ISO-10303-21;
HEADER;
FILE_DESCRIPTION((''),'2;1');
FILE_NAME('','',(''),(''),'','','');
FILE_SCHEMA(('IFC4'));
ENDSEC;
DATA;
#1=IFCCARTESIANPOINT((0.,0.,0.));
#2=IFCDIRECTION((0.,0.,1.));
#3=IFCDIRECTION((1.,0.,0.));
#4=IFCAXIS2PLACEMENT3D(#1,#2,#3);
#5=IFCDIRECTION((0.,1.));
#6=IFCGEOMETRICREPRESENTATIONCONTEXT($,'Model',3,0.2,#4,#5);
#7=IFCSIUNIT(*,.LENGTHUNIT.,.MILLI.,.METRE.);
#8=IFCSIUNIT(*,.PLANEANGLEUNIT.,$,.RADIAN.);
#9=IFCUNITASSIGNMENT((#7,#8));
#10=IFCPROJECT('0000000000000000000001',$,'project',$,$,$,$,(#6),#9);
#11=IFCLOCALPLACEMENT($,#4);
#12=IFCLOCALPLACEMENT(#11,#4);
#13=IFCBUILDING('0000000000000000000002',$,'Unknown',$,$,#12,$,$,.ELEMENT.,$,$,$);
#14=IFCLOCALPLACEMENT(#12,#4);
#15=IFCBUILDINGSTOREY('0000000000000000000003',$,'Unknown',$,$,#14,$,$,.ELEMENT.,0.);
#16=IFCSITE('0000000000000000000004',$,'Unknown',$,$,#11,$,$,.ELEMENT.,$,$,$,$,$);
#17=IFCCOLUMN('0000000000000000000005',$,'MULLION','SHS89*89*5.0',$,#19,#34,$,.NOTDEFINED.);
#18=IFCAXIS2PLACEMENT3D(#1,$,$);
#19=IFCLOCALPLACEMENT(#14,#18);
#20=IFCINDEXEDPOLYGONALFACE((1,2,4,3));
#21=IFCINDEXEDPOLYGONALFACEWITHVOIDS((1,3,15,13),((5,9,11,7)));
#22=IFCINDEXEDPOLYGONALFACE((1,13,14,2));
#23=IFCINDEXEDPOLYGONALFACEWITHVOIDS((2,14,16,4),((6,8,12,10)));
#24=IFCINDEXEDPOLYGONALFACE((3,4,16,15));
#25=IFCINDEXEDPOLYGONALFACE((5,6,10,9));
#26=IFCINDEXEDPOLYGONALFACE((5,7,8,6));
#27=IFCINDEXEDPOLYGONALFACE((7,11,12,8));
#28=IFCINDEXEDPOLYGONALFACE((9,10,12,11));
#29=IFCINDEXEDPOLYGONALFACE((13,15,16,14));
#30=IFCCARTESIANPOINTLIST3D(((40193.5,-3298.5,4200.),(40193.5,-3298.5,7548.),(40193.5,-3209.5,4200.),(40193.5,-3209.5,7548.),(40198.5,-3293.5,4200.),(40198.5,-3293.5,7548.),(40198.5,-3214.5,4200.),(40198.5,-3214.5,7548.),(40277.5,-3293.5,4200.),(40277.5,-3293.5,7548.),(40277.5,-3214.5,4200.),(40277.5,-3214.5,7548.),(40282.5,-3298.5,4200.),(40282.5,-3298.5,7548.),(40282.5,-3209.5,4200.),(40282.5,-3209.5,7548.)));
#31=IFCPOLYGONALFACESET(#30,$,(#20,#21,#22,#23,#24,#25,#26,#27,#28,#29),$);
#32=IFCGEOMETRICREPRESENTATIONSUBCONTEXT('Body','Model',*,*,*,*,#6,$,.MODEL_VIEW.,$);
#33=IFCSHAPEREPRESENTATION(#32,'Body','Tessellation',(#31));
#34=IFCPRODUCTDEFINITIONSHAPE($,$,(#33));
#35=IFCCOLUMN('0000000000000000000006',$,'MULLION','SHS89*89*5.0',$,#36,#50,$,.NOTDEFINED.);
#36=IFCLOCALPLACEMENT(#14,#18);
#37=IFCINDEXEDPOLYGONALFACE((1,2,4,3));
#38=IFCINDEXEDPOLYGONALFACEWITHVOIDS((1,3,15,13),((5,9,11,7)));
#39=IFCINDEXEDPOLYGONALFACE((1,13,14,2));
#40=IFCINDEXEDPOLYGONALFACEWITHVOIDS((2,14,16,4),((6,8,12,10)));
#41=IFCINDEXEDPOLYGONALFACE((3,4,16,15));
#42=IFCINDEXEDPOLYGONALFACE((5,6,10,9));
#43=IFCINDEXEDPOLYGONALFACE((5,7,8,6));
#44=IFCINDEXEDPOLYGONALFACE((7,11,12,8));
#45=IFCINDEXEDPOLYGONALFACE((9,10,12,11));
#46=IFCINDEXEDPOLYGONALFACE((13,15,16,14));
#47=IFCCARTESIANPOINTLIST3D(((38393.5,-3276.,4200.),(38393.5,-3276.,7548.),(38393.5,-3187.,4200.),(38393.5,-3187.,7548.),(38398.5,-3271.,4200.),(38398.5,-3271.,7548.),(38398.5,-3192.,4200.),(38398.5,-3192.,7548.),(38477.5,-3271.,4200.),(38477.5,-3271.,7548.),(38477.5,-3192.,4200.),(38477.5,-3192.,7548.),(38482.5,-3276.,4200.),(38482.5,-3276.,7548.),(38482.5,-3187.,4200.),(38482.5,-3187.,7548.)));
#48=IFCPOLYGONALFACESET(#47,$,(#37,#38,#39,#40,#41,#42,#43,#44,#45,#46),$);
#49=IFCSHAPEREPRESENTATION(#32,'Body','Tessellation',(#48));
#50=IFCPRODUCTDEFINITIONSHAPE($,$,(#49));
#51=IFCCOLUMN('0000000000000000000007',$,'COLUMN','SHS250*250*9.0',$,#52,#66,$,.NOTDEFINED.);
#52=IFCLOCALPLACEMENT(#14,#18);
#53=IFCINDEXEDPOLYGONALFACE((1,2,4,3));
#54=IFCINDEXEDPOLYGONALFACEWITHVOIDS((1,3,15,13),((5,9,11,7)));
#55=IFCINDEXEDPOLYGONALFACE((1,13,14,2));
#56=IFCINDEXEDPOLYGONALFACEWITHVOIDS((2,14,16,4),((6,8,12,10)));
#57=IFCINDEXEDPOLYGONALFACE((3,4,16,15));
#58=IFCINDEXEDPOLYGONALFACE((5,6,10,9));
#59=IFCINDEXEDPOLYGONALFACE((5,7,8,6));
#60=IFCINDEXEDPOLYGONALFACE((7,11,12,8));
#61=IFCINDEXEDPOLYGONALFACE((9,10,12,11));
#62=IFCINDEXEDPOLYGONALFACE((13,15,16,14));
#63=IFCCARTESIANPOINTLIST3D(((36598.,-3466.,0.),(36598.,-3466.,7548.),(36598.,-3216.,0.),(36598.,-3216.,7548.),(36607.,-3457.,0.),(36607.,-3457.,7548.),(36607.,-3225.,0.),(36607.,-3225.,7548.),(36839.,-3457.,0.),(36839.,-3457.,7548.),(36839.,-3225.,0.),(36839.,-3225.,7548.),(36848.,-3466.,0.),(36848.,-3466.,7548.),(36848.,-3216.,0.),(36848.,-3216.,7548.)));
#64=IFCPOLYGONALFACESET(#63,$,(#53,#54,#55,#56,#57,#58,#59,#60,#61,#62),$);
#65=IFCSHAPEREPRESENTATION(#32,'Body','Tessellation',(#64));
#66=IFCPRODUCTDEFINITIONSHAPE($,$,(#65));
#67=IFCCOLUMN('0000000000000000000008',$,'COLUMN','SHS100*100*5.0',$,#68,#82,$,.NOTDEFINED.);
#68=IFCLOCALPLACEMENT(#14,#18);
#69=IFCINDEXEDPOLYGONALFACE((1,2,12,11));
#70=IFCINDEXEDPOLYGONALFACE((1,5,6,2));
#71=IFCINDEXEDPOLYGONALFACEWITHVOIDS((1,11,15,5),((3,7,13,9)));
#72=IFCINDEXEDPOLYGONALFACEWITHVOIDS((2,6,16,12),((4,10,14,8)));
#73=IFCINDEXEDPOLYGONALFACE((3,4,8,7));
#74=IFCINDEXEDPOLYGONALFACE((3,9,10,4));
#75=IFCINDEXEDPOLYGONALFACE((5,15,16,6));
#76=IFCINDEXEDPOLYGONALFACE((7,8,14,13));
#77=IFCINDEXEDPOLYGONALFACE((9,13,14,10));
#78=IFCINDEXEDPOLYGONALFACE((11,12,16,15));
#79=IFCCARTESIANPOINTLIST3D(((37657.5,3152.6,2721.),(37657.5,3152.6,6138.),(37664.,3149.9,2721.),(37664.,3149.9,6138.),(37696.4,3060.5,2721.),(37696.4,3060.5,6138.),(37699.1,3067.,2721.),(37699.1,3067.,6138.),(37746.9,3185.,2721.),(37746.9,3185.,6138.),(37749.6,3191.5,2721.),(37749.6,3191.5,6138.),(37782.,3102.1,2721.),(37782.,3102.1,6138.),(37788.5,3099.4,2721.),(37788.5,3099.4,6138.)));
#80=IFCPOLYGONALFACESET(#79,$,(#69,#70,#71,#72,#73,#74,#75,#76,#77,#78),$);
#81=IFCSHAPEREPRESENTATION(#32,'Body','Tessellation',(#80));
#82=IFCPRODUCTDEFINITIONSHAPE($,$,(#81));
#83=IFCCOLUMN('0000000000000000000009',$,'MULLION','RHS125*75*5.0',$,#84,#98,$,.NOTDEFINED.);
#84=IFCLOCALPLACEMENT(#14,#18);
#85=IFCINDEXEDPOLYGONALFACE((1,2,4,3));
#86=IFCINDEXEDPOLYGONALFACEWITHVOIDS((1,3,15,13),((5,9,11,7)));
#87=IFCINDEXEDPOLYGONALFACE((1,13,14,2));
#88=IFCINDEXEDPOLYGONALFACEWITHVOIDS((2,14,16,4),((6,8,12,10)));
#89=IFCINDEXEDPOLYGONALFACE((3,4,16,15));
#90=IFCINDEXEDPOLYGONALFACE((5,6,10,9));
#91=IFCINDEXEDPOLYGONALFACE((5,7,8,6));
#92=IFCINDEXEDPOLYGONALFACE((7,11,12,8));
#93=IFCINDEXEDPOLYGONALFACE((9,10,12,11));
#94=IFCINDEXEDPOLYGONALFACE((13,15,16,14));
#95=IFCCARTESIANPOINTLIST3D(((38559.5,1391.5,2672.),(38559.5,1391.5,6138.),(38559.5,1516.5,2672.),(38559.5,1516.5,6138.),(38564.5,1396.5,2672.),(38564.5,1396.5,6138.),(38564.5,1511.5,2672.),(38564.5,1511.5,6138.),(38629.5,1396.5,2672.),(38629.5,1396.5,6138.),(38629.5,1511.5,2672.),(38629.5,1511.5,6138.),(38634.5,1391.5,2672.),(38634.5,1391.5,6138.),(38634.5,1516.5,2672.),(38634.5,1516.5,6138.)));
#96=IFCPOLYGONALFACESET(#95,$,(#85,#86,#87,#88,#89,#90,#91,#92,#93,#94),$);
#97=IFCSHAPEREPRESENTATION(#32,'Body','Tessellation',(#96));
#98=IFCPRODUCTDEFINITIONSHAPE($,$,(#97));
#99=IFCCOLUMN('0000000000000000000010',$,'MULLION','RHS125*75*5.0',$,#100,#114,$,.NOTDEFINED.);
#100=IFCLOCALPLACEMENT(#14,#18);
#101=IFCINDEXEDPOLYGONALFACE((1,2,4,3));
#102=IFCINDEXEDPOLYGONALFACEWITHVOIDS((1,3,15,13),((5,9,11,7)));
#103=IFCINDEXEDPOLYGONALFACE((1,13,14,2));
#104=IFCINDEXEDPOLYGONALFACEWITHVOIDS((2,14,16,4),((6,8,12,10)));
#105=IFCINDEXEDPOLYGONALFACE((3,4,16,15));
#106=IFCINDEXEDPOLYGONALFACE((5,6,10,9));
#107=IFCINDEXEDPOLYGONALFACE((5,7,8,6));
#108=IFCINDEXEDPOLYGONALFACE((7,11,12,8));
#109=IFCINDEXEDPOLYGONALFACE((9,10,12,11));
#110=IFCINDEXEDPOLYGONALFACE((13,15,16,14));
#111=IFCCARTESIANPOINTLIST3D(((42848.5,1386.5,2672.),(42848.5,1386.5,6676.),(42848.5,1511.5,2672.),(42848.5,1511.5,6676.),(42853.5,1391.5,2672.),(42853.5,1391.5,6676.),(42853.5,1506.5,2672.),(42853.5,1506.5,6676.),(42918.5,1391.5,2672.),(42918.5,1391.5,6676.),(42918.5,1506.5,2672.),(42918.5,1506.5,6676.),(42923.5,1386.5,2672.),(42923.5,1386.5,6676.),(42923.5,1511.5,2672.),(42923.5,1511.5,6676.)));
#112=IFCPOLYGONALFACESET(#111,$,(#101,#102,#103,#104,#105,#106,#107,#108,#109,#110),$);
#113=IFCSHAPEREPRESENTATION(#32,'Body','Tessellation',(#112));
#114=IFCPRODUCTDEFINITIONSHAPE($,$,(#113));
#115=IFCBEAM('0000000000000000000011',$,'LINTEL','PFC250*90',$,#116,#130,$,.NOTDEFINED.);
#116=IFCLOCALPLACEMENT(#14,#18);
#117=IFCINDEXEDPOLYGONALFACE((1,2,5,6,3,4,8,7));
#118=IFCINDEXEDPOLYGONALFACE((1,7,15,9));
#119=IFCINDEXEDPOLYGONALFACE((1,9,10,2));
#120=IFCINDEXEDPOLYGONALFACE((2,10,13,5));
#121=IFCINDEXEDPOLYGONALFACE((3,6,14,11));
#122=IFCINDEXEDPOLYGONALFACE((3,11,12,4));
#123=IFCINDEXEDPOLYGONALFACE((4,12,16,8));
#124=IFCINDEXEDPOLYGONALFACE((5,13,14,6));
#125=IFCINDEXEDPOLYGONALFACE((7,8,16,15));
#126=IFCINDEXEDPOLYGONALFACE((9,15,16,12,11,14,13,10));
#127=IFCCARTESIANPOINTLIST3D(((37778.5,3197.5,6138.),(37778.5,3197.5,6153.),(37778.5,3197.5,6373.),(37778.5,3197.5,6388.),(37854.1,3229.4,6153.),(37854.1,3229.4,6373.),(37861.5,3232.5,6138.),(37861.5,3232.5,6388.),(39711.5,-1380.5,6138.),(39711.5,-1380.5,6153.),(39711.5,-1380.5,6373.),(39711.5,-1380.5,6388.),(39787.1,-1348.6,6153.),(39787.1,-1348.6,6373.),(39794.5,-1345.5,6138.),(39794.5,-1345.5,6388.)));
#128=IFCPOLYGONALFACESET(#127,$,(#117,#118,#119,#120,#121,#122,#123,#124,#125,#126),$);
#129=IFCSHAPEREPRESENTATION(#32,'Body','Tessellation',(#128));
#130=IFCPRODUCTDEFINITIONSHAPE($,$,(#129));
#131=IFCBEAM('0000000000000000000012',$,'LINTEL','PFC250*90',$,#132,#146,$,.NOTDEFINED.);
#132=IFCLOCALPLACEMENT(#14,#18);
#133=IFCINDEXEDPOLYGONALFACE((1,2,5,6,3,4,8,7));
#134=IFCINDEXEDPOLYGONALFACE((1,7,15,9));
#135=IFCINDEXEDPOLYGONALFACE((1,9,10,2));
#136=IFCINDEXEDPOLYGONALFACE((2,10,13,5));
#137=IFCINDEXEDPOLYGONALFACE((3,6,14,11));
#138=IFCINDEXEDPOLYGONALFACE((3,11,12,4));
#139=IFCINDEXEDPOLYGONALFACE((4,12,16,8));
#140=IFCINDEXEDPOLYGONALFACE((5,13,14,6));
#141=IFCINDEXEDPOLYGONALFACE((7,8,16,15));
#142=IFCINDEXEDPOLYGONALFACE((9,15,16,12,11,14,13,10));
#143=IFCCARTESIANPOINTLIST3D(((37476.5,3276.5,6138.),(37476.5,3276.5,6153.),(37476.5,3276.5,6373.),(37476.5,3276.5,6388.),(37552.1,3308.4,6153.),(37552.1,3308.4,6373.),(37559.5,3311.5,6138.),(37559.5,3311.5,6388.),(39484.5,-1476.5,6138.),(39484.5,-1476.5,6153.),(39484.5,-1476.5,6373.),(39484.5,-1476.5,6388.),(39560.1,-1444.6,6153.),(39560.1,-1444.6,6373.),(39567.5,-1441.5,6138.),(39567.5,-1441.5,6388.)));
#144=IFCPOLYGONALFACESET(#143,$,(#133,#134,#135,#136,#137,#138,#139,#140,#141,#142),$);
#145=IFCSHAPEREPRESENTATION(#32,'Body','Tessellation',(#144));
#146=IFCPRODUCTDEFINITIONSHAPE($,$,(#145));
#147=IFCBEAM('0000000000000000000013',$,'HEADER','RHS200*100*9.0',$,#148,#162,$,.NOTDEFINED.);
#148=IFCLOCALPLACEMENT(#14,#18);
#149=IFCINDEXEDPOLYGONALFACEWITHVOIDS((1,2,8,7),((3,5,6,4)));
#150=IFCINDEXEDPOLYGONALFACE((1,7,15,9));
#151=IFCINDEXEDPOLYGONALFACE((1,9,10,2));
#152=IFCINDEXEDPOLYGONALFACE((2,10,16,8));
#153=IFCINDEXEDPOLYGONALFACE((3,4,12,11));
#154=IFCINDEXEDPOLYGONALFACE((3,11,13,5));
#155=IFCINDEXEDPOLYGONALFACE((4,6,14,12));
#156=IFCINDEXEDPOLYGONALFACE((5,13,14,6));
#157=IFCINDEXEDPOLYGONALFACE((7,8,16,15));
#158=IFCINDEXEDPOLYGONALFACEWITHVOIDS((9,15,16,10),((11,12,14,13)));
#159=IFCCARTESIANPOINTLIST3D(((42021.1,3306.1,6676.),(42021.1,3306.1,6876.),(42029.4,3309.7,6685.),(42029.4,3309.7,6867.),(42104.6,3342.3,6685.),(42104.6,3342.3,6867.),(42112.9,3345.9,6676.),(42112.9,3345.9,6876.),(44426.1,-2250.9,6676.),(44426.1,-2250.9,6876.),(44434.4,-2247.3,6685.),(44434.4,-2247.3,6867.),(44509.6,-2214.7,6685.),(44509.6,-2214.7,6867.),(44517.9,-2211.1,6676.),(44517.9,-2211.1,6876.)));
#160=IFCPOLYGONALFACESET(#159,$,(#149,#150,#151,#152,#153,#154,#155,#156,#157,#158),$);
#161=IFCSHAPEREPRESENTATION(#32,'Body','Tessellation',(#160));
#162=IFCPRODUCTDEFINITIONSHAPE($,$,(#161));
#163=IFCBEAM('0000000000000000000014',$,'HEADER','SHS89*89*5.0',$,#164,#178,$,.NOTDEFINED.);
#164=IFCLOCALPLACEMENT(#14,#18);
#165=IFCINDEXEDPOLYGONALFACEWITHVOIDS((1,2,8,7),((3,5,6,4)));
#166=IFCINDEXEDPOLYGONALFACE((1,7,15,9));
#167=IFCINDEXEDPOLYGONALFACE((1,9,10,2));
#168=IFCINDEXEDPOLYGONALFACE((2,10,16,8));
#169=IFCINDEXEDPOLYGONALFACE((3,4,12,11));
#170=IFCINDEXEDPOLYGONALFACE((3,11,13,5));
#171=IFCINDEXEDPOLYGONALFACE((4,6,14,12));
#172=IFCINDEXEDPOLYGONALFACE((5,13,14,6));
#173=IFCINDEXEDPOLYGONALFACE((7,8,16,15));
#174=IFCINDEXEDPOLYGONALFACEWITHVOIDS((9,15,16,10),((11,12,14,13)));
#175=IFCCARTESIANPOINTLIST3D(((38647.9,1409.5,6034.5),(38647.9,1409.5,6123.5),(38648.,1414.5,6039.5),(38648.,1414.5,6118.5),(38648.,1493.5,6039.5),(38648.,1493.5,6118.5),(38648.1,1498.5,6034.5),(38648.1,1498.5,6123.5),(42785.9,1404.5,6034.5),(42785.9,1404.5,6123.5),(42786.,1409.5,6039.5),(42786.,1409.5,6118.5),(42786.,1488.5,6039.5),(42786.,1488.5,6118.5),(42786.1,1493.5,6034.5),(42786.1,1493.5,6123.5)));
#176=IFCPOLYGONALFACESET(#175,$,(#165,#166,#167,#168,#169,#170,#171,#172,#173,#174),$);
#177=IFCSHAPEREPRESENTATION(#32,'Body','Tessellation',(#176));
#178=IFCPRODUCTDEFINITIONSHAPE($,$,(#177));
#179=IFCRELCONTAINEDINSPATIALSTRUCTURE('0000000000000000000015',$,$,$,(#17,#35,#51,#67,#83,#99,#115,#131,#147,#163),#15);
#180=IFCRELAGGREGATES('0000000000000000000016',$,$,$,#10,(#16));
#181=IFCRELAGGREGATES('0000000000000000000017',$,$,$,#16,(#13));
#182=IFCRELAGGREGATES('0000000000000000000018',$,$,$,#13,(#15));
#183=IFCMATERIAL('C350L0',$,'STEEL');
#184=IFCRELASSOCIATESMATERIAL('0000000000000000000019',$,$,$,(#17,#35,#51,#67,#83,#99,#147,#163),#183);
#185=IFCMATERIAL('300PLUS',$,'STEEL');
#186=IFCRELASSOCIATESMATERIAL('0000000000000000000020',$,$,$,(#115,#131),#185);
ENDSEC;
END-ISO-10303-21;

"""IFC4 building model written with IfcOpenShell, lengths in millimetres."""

from ifc_helpers import new_model, si_unit, direction, frame, origin_with_axes, place, context, subcontext, project, spatial, line, indexed_curve, outline, extrude, material, element, save


model = new_model("IFC4")

# Units and contexts
model_context = context("Model", 3, precision=0.2, world=origin_with_axes(), true_north=direction((0.0, 1.0)))
body_context = subcontext(model_context, "Body", "Model", "MODEL_VIEW")
ifc_project = project(units=[si_unit("LENGTHUNIT", "METRE", prefix="MILLI"), si_unit("PLANEANGLEUNIT", "RADIAN")], contexts=[model_context])

# Site, building, storey
site_placement = place(None, origin_with_axes())
site = spatial("IfcSite", under=ifc_project, at=site_placement, Name="Unknown", CompositionType="ELEMENT")
building_placement = place(site_placement, origin_with_axes())
building = spatial("IfcBuilding", under=site, at=building_placement, Name="Unknown", CompositionType="ELEMENT")
storey_placement = place(building_placement, origin_with_axes())
storey = spatial("IfcBuildingStorey", under=building, at=storey_placement, Name="Unknown", CompositionType="ELEMENT", Elevation=0.0)

# Columns
ifc_material_1 = material(Name="C350L0", Category="STEEL")
for number, where, z_axis, x_axis, name in (
    (1, (40238.0, -3254.0, 4200.0), (0.000017, -1.0, 0.0), (0.0, 0.0, 1.0), "MULLION"),
    (2, (38438.0, -3231.5, 4200.0), (0.000017, -1.0, 0.0), (0.0, 0.0, 1.0), "MULLION"),
):
    element("IfcColumn", number, at=place(storey_placement, frame(where, z_axis=z_axis, x_axis=x_axis)), inside=storey, material=ifc_material_1, Name=name, Description="SHS89*89*5.0", PredefinedType="NOTDEFINED", context=body_context, shape_type="SolidModel", body=[
        extrude(outline(indexed_curve([(-44.5, -44.5), (44.5, -44.5), (44.5, 44.5), (-44.5, 44.5)], segments=[line(1, 2, 3, 4, 1)]), holes=[indexed_curve([(-39.5, -39.5), (-39.5, 39.5), (39.5, 39.5), (39.5, -39.5)], segments=[line(1, 2, 3, 4, 1)])]), frame((0.0, 0.0, 0.0), z_axis=(-1.0, 0.0, 0.0), x_axis=(0.0, 0.0, 1.0)), (0.0, 0.0, -1.0), 3348.0),
    ])
column_1_placement = place(storey_placement, frame((36723.0, -3341.0, 0.0), z_axis=(0.000017, -1.0, 0.0), x_axis=(0.0, 0.0, 1.0)))
element("IfcColumn", 3, at=column_1_placement, inside=storey, material=ifc_material_1, Name="COLUMN", Description="SHS250*250*9.0", PredefinedType="NOTDEFINED", context=body_context, shape_type="SolidModel", body=[
    extrude(outline(indexed_curve([(-125.0, -125.0), (125.0, -125.0), (125.0, 125.0), (-125.0, 125.0)], segments=[line(1, 2, 3, 4, 1)]), holes=[indexed_curve([(-116.0, -116.0), (-116.0, 116.0), (116.0, 116.0), (116.0, -116.0)], segments=[line(1, 2, 3, 4, 1)])]), frame((0.0, 0.0, 0.0), z_axis=(-1.0, 0.0, 0.0), x_axis=(0.0, 0.0, 1.0)), (0.0, 0.0, -1.0), 7548.0),
])
column_2_placement = place(storey_placement, frame((37723.0, 3126.0, 2721.0), z_axis=(0.921185, 0.389124, 0.0), x_axis=(0.0, 0.0, 1.0)))
element("IfcColumn", 4, at=column_2_placement, inside=storey, material=ifc_material_1, Name="COLUMN", Description="SHS100*100*5.0", PredefinedType="NOTDEFINED", context=body_context, shape_type="SolidModel", body=[
    extrude(outline(indexed_curve([(-50.0, -50.0), (50.0, -50.0), (50.0, 50.0), (-50.0, 50.0)], segments=[line(1, 2, 3, 4, 1)]), holes=[indexed_curve([(-45.0, -45.0), (-45.0, 45.0), (45.0, 45.0), (45.0, -45.0)], segments=[line(1, 2, 3, 4, 1)])]), frame((0.0, 0.0, 0.0), z_axis=(-1.0, 0.0, 0.0), x_axis=(0.0, 0.0, 1.0)), (0.0, 0.0, -1.0), 3417.0),
])
column_3_placement = place(storey_placement, frame((38597.0, 1454.0, 2672.0), z_axis=(1.0, 0.0, 0.0), x_axis=(0.0, 0.0, 1.0)))
element("IfcColumn", 5, at=column_3_placement, inside=storey, material=ifc_material_1, Name="MULLION", Description="RHS125*75*5.0", PredefinedType="NOTDEFINED", context=body_context, shape_type="SolidModel", body=[
    extrude(outline(indexed_curve([(-37.5, -62.5), (37.5, -62.5), (37.5, 62.5), (-37.5, 62.5)], segments=[line(1, 2, 3, 4, 1)]), holes=[indexed_curve([(-32.5, -57.5), (-32.5, 57.5), (32.5, 57.5), (32.5, -57.5)], segments=[line(1, 2, 3, 4, 1)])]), frame((0.0, 0.0, 0.0), z_axis=(-1.0, 0.0, 0.0), x_axis=(0.0, 0.0, 1.0)), (0.0, 0.0, -1.0), 3466.0),
])
column_4_placement = place(storey_placement, frame((42886.0, 1449.0, 2672.0), z_axis=(1.0, 0.0, 0.0), x_axis=(0.0, 0.0, 1.0)))
element("IfcColumn", 6, at=column_4_placement, inside=storey, material=ifc_material_1, Name="MULLION", Description="RHS125*75*5.0", PredefinedType="NOTDEFINED", context=body_context, shape_type="SolidModel", body=[
    extrude(outline(indexed_curve([(-37.5, -62.5), (37.5, -62.5), (37.5, 62.5), (-37.5, 62.5)], segments=[line(1, 2, 3, 4, 1)]), holes=[indexed_curve([(-32.5, -57.5), (-32.5, 57.5), (32.5, 57.5), (32.5, -57.5)], segments=[line(1, 2, 3, 4, 1)])]), frame((0.0, 0.0, 0.0), z_axis=(-1.0, 0.0, 0.0), x_axis=(0.0, 0.0, 1.0)), (0.0, 0.0, -1.0), 4004.0),
])

# Beams
ifc_material_2 = material(Name="300PLUS", Category="STEEL")
beam_1_placement = place(storey_placement, frame((37820.0, 3215.0, 6263.0), z_axis=(-0.921245, -0.388983, 0.0), x_axis=(0.388983, -0.921245, 0.0)))
element("IfcBeam", 7, at=beam_1_placement, inside=storey, material=ifc_material_2, Name="LINTEL", Description="PFC250*90", PredefinedType="NOTDEFINED", context=body_context, shape_type="SolidModel", body=[
    extrude(outline(indexed_curve([(-45.0, -125.0), (45.0, -125.0), (45.0, -110.0), (-37.0, -110.0), (-37.0, 110.0), (45.0, 110.0), (45.0, 125.0), (-45.0, 125.0)], segments=[line(1, 2, 3, 4, 5, 6, 7, 8, 1)])), frame((0.0, 0.0, 0.0), z_axis=(-1.0, 0.0, 0.0), x_axis=(0.0, 0.0, 1.0)), (0.0, 0.0, -1.0), 4969.4),
])
beam_2_placement = place(storey_placement, frame((37518.0, 3294.0, 6263.0), z_axis=(-0.921168, -0.389166, 0.0), x_axis=(0.389166, -0.921168, 0.0)))
element("IfcBeam", 8, at=beam_2_placement, inside=storey, material=ifc_material_2, Name="LINTEL", Description="PFC250*90", PredefinedType="NOTDEFINED", context=body_context, shape_type="SolidModel", body=[
    extrude(outline(indexed_curve([(-45.0, -125.0), (45.0, -125.0), (45.0, -110.0), (-37.0, -110.0), (-37.0, 110.0), (45.0, 110.0), (45.0, 125.0), (-45.0, 125.0)], segments=[line(1, 2, 3, 4, 5, 6, 7, 8, 1)])), frame((0.0, 0.0, 0.0), z_axis=(-1.0, 0.0, 0.0), x_axis=(0.0, 0.0, 1.0)), (0.0, 0.0, -1.0), 5159.8),
])
beam_3_placement = place(storey_placement, frame((42067.0, 3326.0, 6776.0), z_axis=(-0.917738, -0.397186, 0.0), x_axis=(0.397186, -0.917738, 0.0)))
element("IfcBeam", 9, at=beam_3_placement, inside=storey, material=ifc_material_1, Name="HEADER", Description="RHS200*100*9.0", PredefinedType="NOTDEFINED", context=body_context, shape_type="SolidModel", body=[
    extrude(outline(indexed_curve([(-50.0, -100.0), (50.0, -100.0), (50.0, 100.0), (-50.0, 100.0)], segments=[line(1, 2, 3, 4, 1)]), holes=[indexed_curve([(-41.0, -91.0), (-41.0, 91.0), (41.0, 91.0), (41.0, -91.0)], segments=[line(1, 2, 3, 4, 1)])]), frame((0.0, 0.0, 0.0), z_axis=(-1.0, 0.0, 0.0), x_axis=(0.0, 0.0, 1.0)), (0.0, 0.0, -1.0), 6055.1),
])
beam_4_placement = place(storey_placement, frame((42786.0, 1449.0, 6079.0), z_axis=(0.0, 0.0, 1.0), x_axis=(-0.999999, 0.001208, 0.0)))
element("IfcBeam", 10, at=beam_4_placement, inside=storey, material=ifc_material_1, Name="HEADER", Description="SHS89*89*5.0", PredefinedType="NOTDEFINED", context=body_context, shape_type="SolidModel", body=[
    extrude(outline(indexed_curve([(-44.5, -44.5), (44.5, -44.5), (44.5, 44.5), (-44.5, 44.5)], segments=[line(1, 2, 3, 4, 1)]), holes=[indexed_curve([(-39.5, -39.5), (-39.5, 39.5), (39.5, 39.5), (39.5, -39.5)], segments=[line(1, 2, 3, 4, 1)])]), frame((0.0, 0.0, 0.0), z_axis=(-1.0, 0.0, 0.0), x_axis=(0.0, 0.0, 1.0)), (0.0, 0.0, -1.0), 4138.0),
])

save(model, "model.ifc")
